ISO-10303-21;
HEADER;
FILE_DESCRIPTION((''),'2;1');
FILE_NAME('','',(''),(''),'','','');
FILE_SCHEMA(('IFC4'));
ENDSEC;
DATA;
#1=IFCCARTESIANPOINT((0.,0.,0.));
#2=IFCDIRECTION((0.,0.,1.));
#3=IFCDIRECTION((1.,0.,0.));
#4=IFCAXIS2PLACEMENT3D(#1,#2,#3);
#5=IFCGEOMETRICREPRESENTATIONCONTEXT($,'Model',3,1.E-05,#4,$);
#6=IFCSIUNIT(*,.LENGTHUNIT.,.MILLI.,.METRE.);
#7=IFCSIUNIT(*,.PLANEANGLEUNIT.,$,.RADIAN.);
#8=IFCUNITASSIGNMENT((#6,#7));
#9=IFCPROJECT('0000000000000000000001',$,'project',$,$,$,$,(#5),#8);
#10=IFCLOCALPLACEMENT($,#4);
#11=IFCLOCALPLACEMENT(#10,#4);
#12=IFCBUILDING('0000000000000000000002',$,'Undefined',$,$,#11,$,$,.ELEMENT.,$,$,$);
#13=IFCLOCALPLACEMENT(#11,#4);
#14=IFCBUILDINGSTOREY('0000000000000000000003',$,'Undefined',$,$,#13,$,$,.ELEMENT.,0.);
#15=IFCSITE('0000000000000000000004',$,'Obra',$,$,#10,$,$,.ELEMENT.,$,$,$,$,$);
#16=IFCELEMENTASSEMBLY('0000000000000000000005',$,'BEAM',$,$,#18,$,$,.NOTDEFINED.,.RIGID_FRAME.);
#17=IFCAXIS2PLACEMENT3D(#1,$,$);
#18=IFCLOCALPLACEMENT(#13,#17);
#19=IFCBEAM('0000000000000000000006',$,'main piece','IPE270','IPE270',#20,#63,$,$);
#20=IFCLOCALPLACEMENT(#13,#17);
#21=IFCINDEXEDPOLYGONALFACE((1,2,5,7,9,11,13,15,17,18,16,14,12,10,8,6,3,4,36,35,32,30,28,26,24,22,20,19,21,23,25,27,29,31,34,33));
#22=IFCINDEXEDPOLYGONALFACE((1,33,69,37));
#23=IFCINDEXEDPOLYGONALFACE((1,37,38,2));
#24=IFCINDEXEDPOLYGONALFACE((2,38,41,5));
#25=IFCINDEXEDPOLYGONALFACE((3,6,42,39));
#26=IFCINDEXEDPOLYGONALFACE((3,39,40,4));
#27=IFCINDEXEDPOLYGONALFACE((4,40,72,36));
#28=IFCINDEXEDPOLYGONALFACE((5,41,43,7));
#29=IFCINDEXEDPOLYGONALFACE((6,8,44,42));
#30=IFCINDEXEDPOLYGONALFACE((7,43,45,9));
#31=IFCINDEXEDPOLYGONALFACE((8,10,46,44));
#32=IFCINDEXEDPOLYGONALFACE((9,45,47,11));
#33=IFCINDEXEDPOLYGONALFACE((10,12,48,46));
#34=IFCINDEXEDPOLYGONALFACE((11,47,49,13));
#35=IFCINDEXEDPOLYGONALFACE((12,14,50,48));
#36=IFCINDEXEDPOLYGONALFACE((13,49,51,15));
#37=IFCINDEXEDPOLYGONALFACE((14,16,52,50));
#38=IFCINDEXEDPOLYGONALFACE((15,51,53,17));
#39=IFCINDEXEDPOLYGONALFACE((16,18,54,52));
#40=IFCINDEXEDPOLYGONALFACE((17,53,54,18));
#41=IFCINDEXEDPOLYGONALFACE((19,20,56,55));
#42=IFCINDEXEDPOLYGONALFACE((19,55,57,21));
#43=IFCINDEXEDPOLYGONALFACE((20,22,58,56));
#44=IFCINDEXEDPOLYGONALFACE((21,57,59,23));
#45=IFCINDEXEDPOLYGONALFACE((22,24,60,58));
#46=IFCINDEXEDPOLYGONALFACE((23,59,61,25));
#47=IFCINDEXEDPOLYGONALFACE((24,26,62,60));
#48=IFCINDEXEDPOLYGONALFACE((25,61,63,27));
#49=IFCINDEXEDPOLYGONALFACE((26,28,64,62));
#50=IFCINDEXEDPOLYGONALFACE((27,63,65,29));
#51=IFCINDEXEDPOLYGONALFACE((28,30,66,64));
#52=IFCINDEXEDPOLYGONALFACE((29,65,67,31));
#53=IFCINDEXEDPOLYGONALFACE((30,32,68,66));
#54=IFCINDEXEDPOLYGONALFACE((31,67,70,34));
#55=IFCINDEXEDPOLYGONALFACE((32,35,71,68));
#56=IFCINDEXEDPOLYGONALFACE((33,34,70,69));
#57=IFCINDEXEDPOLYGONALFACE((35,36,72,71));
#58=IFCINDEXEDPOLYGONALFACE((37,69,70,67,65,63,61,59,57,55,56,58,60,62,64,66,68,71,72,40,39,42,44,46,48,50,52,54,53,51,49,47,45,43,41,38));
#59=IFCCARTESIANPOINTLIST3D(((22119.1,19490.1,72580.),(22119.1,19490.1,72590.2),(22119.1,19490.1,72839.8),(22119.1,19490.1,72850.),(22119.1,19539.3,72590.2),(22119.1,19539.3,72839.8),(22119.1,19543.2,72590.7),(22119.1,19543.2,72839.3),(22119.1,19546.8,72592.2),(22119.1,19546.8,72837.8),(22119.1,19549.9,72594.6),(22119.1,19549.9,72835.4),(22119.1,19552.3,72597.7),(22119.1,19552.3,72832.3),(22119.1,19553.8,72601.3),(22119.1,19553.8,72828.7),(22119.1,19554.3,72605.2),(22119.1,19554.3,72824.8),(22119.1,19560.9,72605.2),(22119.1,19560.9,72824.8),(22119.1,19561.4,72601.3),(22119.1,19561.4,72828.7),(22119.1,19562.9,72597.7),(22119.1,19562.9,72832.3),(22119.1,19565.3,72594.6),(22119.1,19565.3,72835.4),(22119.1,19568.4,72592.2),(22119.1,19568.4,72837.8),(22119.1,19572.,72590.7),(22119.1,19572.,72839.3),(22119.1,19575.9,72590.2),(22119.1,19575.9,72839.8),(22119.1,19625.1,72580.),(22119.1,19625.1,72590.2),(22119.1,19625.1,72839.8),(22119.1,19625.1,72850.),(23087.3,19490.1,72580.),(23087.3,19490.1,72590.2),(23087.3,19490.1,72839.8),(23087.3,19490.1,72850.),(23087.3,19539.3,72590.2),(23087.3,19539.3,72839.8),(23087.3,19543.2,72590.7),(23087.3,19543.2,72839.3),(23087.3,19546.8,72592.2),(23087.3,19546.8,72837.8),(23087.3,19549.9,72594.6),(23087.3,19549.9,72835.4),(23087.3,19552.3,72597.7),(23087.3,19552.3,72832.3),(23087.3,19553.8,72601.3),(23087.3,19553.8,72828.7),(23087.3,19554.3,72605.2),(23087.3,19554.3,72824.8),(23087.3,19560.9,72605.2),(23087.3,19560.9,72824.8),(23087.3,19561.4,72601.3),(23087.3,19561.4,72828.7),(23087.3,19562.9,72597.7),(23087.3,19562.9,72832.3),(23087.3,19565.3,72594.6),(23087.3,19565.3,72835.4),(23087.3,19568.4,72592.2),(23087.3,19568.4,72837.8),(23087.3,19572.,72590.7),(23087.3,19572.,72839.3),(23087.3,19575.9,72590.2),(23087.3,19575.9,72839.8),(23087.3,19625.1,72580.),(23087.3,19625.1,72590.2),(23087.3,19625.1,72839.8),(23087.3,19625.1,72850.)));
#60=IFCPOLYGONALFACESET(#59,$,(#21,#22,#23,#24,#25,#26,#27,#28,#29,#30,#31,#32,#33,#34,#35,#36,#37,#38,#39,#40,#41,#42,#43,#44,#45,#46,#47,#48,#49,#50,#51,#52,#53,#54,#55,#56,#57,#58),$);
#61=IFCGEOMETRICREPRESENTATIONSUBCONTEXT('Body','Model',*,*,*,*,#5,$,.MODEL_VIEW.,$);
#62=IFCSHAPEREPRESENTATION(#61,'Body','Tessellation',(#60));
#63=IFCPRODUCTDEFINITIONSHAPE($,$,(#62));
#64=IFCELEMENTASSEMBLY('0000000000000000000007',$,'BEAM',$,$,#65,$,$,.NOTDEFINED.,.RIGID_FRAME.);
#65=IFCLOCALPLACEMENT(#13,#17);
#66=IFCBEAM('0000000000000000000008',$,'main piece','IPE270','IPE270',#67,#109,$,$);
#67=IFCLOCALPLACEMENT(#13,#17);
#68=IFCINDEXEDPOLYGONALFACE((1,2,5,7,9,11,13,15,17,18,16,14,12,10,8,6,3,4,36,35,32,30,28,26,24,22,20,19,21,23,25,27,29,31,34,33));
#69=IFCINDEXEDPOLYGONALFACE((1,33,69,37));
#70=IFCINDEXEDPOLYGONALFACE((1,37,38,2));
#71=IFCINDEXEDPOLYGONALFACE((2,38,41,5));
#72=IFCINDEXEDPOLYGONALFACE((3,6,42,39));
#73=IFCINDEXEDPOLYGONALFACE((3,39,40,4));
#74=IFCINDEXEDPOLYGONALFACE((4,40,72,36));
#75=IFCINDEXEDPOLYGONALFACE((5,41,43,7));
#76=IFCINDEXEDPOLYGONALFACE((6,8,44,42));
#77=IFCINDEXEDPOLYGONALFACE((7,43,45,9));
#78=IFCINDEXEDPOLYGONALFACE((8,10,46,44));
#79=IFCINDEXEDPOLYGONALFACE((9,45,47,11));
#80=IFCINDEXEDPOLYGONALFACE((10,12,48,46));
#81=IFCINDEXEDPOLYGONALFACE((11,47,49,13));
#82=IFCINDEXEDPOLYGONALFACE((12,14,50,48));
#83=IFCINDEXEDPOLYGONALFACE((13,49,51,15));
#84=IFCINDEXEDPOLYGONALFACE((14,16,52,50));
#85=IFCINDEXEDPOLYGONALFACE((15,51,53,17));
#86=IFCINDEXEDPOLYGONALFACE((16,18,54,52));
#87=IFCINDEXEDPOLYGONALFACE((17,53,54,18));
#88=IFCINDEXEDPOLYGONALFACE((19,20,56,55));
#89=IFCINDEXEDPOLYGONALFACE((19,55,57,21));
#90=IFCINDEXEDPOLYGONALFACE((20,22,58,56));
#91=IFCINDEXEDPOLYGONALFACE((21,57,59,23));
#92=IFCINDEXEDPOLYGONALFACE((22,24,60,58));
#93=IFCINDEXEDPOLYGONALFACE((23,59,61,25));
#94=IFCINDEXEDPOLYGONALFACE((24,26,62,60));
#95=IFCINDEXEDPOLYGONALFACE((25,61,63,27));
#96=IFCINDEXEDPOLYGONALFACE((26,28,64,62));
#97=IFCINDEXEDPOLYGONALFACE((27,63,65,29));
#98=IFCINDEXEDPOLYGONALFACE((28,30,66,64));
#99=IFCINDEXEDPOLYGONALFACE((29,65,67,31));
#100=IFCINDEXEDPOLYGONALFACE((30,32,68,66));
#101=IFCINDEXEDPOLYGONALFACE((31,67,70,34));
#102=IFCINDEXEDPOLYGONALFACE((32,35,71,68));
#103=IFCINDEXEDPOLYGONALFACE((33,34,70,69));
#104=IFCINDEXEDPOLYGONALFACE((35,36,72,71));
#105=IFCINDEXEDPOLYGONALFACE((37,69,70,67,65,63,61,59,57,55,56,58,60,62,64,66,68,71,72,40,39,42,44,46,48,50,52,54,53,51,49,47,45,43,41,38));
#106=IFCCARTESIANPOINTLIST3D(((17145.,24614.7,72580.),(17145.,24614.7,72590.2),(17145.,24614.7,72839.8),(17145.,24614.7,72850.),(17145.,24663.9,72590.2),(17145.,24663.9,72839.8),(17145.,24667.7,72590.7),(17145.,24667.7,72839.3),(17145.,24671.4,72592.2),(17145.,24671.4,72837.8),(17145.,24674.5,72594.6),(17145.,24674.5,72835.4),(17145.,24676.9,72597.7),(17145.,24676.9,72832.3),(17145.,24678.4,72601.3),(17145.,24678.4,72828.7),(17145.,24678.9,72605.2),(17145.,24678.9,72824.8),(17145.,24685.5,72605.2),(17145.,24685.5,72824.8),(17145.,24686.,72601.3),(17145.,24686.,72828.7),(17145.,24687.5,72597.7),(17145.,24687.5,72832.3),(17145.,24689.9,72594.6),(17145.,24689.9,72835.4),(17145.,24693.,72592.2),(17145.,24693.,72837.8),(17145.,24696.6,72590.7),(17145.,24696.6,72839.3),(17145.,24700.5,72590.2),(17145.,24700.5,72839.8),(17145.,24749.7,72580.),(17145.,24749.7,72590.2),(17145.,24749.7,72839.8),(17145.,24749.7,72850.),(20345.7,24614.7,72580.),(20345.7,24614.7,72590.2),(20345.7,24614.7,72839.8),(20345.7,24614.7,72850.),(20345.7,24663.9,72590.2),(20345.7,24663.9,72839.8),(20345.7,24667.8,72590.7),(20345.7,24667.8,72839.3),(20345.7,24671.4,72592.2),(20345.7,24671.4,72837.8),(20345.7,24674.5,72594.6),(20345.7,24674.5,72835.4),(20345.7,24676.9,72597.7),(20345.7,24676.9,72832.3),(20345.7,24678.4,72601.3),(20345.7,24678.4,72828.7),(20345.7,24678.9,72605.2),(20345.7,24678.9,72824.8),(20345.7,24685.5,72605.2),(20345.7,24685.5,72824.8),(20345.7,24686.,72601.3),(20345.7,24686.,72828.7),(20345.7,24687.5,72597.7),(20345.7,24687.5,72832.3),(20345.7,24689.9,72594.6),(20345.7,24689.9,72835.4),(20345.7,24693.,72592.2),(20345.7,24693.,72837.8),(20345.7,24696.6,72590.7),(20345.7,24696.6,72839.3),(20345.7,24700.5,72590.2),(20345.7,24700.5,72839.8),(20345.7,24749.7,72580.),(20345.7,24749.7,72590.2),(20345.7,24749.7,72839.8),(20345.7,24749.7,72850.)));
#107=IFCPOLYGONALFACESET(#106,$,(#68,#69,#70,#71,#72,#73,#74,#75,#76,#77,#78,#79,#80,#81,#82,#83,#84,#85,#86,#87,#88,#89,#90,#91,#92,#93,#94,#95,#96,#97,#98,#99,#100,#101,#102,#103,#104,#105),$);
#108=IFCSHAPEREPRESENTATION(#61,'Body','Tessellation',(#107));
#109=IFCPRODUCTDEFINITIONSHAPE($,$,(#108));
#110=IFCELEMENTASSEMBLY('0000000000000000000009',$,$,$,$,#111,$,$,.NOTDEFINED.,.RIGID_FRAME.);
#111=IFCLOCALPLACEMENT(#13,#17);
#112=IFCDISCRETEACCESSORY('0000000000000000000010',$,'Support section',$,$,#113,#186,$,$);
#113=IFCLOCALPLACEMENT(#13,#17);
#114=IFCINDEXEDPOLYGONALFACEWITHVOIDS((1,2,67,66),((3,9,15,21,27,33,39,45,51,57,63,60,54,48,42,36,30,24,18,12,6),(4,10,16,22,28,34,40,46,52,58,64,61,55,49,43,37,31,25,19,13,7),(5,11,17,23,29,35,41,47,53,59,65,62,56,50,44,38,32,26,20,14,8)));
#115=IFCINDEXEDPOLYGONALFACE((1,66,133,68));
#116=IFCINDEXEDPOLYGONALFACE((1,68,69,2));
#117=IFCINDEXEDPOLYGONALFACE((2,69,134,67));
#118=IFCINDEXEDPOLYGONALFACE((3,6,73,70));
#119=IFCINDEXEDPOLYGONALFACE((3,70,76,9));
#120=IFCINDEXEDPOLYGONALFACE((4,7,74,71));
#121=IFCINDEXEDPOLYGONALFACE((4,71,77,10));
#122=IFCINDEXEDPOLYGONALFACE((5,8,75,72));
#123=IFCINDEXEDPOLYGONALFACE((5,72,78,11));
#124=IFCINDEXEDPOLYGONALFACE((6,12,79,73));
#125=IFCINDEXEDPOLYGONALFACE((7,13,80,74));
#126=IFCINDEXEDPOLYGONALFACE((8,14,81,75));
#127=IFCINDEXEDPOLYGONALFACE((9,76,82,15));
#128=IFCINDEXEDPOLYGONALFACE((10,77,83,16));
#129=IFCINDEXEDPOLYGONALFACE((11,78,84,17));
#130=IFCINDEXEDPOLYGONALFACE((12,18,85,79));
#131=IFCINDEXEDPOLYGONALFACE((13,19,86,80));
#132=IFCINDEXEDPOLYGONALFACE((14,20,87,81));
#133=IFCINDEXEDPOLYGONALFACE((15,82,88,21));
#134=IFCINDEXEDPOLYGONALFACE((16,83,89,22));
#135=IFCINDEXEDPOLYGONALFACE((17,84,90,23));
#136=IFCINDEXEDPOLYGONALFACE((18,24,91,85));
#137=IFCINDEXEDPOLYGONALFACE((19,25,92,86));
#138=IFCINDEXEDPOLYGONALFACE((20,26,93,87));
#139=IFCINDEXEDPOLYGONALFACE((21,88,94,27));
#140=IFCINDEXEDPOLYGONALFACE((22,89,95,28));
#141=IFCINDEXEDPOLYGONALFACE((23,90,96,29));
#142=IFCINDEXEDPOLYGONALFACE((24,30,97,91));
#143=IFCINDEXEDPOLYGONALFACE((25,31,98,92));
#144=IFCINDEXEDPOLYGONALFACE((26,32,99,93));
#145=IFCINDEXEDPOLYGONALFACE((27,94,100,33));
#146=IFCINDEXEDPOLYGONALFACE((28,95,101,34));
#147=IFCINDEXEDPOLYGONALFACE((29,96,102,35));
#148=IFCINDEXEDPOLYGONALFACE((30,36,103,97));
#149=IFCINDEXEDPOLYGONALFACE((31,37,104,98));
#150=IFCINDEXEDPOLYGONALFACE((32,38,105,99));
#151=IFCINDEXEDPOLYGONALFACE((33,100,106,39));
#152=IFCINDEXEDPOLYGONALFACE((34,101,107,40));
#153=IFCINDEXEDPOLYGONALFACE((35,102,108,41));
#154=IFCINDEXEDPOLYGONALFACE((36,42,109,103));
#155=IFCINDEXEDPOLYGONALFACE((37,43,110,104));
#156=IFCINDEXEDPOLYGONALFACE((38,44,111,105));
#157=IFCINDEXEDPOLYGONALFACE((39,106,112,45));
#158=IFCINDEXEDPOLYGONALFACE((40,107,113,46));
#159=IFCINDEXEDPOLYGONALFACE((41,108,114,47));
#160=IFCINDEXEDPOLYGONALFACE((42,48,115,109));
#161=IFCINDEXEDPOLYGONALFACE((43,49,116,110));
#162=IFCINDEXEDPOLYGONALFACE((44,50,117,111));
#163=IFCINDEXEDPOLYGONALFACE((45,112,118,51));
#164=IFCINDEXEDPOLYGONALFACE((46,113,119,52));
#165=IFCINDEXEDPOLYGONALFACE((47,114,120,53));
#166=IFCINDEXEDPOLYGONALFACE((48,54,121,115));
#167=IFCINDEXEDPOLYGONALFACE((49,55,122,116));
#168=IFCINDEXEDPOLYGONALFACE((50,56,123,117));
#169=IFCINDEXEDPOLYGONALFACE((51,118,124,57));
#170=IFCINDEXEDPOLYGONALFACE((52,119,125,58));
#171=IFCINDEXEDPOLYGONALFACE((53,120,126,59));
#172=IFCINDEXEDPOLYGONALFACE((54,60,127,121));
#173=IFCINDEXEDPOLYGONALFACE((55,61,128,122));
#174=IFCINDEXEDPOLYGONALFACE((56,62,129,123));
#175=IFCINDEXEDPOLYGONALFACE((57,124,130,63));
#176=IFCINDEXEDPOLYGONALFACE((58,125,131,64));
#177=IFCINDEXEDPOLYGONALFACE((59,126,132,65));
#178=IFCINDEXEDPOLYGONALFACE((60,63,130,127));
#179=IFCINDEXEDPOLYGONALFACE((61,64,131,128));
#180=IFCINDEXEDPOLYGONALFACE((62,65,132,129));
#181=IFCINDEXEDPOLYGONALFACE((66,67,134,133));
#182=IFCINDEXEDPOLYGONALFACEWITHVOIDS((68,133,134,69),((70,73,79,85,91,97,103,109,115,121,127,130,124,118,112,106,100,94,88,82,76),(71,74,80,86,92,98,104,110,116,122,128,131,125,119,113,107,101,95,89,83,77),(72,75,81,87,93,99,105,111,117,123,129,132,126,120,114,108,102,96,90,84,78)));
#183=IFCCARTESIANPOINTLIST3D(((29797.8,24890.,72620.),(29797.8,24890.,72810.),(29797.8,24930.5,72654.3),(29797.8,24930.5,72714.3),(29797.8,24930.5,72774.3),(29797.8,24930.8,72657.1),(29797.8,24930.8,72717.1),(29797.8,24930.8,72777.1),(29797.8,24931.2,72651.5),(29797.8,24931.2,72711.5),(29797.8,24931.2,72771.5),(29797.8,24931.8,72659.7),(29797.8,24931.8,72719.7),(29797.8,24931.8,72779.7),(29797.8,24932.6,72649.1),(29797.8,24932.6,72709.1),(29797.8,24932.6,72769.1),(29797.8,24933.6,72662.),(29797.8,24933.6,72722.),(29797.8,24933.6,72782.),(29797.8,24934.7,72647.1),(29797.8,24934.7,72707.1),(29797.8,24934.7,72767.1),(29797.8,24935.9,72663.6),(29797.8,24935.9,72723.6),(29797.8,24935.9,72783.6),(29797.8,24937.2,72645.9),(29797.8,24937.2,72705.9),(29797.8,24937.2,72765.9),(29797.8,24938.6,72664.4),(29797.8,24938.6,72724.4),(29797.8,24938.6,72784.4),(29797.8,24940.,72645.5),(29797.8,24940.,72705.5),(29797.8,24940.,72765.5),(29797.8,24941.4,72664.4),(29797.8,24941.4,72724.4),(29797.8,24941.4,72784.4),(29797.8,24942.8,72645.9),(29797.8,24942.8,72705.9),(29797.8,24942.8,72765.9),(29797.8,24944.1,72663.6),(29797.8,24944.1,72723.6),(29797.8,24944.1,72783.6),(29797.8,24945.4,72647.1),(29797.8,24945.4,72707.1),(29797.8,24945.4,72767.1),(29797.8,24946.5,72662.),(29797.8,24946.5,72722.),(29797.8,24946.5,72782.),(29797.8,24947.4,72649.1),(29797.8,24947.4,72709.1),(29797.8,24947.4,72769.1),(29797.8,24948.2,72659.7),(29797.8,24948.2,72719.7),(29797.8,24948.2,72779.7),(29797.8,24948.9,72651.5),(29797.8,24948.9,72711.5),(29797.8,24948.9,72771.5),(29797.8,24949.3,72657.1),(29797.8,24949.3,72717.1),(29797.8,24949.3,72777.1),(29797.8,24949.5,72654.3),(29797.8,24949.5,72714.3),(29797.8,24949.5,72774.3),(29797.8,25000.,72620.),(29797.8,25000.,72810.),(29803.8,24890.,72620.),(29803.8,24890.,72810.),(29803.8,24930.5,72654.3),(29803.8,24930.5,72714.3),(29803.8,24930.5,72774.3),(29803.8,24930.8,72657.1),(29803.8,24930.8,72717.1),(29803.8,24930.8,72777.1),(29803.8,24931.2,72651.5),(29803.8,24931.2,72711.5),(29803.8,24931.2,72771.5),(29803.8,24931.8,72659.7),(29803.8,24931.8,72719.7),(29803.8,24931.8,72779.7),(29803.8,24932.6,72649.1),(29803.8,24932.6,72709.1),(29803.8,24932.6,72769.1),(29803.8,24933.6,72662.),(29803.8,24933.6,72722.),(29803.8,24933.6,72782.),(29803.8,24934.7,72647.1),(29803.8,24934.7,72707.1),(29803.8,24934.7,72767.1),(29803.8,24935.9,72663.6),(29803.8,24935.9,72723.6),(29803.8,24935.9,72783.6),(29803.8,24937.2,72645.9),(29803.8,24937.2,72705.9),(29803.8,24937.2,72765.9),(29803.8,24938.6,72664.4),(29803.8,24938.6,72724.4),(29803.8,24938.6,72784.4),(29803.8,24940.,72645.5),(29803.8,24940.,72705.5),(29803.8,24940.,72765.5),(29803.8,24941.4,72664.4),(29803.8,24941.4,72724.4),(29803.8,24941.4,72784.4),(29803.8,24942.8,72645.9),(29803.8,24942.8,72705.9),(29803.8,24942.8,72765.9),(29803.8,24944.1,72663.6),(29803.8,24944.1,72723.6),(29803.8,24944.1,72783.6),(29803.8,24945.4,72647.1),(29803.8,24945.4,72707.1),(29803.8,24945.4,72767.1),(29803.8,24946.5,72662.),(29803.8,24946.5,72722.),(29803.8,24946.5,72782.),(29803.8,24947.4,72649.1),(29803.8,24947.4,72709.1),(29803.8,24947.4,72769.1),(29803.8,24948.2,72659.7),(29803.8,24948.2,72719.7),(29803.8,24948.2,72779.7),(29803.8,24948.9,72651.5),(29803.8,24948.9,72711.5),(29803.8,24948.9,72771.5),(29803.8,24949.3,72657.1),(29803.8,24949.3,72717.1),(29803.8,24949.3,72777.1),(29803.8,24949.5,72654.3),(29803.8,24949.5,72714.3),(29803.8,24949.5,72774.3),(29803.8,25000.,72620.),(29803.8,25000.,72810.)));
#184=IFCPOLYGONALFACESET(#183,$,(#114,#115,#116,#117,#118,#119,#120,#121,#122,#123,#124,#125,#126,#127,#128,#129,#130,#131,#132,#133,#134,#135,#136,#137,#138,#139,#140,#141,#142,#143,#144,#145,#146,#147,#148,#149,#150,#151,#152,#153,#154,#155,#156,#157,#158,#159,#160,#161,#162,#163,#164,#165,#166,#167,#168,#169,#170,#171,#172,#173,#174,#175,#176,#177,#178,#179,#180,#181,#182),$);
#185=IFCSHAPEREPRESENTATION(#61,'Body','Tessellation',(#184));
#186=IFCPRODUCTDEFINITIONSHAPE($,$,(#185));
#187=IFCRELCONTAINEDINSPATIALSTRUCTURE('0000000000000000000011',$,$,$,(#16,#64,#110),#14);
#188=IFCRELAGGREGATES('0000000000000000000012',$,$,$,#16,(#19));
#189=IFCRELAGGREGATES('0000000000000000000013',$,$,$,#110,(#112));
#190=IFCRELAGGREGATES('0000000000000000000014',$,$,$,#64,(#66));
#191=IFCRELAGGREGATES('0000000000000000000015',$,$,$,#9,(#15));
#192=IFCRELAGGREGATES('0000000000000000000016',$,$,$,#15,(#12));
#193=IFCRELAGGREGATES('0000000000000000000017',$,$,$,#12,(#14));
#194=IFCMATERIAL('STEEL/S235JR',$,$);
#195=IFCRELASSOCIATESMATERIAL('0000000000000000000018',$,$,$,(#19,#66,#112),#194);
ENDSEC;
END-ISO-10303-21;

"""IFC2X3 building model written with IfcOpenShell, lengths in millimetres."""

from ifc_helpers import new_model, si_unit, frame, origin_with_axes, origin_2d_with_axis, place, context, subcontext, project, spatial, rectangle, circle, i_section, extrude, source, transform, mapped, material, element, aggregate, save


model = new_model("IFC2X3")

# Units and contexts
model_context = context("Model", 3, precision=1e-05, world=origin_with_axes())
body_context = subcontext(model_context, "Body", "Model", "MODEL_VIEW")
ifc_project = project(units=[si_unit("LENGTHUNIT", "METRE", prefix="MILLI"), si_unit("PLANEANGLEUNIT", "RADIAN")], contexts=[model_context])

# Site, building, storey
site_placement = place(None, origin_with_axes())
site = spatial("IfcSite", under=ifc_project, at=site_placement, Name="Obra", CompositionType="ELEMENT")
building_placement = place(site_placement, origin_with_axes())
building = spatial("IfcBuilding", under=site, at=building_placement, Name="Undefined", CompositionType="ELEMENT")
storey_placement = place(building_placement, origin_with_axes())
storey = spatial("IfcBuildingStorey", under=building, at=storey_placement, Name="Undefined", CompositionType="ELEMENT", Elevation=0.0)

# Shared definitions
ifc_material_1 = material(Name="STEEL/S235JR")

# Element assembly, beam
assembly_1_placement = place(storey_placement, origin_with_axes())
assembly_1 = element("IfcElementAssembly", 1, at=assembly_1_placement, inside=storey, Name="BEAM", AssemblyPlace="NOTDEFINED", PredefinedType="RIGID_FRAME")
beam_1_placement = place(assembly_1_placement, frame((22119.1, 19557.6, 72715.0), z_axis=(0.0, 0.0, 1.0), x_axis=(1.0, 0.0, 0.0)))
beam_1 = element("IfcBeam", 2, at=beam_1_placement, material=ifc_material_1, Name="main piece", Description="IPE270", ObjectType="IPE270", context=body_context, shape_type="SweptSolid", body=[
    extrude(i_section(OverallWidth=135.0, OverallDepth=270.0, WebThickness=6.6, FlangeThickness=10.2, FilletRadius=15.0, at=origin_2d_with_axis()), frame((968.2, 0.0, 0.0), z_axis=(-1.0, 0.0, 0.0), x_axis=(0.0, -1.0, 0.0)), (0.0, 0.0, 1.0), 968.2),
])
aggregate(assembly_1, [beam_1])

# Element assembly, beam
assembly_2_placement = place(storey_placement, origin_with_axes())
assembly_2 = element("IfcElementAssembly", 3, at=assembly_2_placement, inside=storey, Name="BEAM", AssemblyPlace="NOTDEFINED", PredefinedType="RIGID_FRAME")
beam_2_placement = place(assembly_2_placement, frame((17145.0, 24682.2, 72715.0), z_axis=(0.0, 0.0, 1.0), x_axis=(1.0, 0.000002, 0.0)))
beam_2 = element("IfcBeam", 4, at=beam_2_placement, material=ifc_material_1, Name="main piece", Description="IPE270", ObjectType="IPE270", context=body_context, shape_type="SweptSolid", body=[
    extrude(i_section(OverallWidth=135.0, OverallDepth=270.0, WebThickness=6.6, FlangeThickness=10.2, FilletRadius=15.0, at=origin_2d_with_axis()), frame((3200.7, 0.0, 0.0), z_axis=(-1.0, 0.0, 0.0), x_axis=(0.0, -1.0, 0.0)), (0.0, 0.0, 1.0), 3200.7),
])

# Element assembly, discrete accessory, opening
assembly_3_placement = place(storey_placement, origin_with_axes())
assembly_3 = element("IfcElementAssembly", 5, at=assembly_3_placement, inside=storey, AssemblyPlace="NOTDEFINED", PredefinedType="RIGID_FRAME")
discrete_accessory_1_placement = place(assembly_3_placement, frame((29800.8, 24945.0, 72620.0), z_axis=(0.0, 0.0, 1.0), x_axis=(-0.000002, 1.0, 0.0)))
discrete_accessory_1 = element("IfcDiscreteAccessory", 6, at=discrete_accessory_1_placement, material=ifc_material_1, Name="Support section", context=body_context, shape_type="SweptSolid", body=[
    extrude(rectangle(XDim=6.0, YDim=110.0, at=origin_2d_with_axis()), frame((0.0, 0.0, 190.0), z_axis=(0.0, 0.0, -1.0), x_axis=(0.0, 1.0, 0.0)), (0.0, 0.0, 1.0), 190.0),
])
shared_shape_1 = source(origin_with_axes(), body_context, "Body", "SweptSolid", [
    extrude(circle(Radius=9.5, at=origin_2d_with_axis()), frame((0.0, -9.2, 0.0), z_axis=(0.0, 1.0, 0.0), x_axis=(1.0, 0.0, 0.0)), (0.0, 0.0, 1.0), 6.2),
])
opening_1_placement = place(assembly_3_placement, frame((29806.9, 24990.0, 72835.0), z_axis=(0.000002, -1.0, 0.0), x_axis=(0.0, 0.0, -1.0)))
element("IfcOpeningElement", 7, at=opening_1_placement, cuts=discrete_accessory_1, ObjectType="Opening", context=body_context, shape_type="MappedRepresentation", body=[
    mapped(shared_shape_1, transform((60.0, 0.0, 50.0))),
    mapped(shared_shape_1, transform((120.0, 0.0, 50.0))),
    mapped(shared_shape_1, transform((180.0, 0.0, 50.0))),
])
aggregate(assembly_3, [discrete_accessory_1])

aggregate(assembly_2, [beam_2])

save(model, "model.ifc")
